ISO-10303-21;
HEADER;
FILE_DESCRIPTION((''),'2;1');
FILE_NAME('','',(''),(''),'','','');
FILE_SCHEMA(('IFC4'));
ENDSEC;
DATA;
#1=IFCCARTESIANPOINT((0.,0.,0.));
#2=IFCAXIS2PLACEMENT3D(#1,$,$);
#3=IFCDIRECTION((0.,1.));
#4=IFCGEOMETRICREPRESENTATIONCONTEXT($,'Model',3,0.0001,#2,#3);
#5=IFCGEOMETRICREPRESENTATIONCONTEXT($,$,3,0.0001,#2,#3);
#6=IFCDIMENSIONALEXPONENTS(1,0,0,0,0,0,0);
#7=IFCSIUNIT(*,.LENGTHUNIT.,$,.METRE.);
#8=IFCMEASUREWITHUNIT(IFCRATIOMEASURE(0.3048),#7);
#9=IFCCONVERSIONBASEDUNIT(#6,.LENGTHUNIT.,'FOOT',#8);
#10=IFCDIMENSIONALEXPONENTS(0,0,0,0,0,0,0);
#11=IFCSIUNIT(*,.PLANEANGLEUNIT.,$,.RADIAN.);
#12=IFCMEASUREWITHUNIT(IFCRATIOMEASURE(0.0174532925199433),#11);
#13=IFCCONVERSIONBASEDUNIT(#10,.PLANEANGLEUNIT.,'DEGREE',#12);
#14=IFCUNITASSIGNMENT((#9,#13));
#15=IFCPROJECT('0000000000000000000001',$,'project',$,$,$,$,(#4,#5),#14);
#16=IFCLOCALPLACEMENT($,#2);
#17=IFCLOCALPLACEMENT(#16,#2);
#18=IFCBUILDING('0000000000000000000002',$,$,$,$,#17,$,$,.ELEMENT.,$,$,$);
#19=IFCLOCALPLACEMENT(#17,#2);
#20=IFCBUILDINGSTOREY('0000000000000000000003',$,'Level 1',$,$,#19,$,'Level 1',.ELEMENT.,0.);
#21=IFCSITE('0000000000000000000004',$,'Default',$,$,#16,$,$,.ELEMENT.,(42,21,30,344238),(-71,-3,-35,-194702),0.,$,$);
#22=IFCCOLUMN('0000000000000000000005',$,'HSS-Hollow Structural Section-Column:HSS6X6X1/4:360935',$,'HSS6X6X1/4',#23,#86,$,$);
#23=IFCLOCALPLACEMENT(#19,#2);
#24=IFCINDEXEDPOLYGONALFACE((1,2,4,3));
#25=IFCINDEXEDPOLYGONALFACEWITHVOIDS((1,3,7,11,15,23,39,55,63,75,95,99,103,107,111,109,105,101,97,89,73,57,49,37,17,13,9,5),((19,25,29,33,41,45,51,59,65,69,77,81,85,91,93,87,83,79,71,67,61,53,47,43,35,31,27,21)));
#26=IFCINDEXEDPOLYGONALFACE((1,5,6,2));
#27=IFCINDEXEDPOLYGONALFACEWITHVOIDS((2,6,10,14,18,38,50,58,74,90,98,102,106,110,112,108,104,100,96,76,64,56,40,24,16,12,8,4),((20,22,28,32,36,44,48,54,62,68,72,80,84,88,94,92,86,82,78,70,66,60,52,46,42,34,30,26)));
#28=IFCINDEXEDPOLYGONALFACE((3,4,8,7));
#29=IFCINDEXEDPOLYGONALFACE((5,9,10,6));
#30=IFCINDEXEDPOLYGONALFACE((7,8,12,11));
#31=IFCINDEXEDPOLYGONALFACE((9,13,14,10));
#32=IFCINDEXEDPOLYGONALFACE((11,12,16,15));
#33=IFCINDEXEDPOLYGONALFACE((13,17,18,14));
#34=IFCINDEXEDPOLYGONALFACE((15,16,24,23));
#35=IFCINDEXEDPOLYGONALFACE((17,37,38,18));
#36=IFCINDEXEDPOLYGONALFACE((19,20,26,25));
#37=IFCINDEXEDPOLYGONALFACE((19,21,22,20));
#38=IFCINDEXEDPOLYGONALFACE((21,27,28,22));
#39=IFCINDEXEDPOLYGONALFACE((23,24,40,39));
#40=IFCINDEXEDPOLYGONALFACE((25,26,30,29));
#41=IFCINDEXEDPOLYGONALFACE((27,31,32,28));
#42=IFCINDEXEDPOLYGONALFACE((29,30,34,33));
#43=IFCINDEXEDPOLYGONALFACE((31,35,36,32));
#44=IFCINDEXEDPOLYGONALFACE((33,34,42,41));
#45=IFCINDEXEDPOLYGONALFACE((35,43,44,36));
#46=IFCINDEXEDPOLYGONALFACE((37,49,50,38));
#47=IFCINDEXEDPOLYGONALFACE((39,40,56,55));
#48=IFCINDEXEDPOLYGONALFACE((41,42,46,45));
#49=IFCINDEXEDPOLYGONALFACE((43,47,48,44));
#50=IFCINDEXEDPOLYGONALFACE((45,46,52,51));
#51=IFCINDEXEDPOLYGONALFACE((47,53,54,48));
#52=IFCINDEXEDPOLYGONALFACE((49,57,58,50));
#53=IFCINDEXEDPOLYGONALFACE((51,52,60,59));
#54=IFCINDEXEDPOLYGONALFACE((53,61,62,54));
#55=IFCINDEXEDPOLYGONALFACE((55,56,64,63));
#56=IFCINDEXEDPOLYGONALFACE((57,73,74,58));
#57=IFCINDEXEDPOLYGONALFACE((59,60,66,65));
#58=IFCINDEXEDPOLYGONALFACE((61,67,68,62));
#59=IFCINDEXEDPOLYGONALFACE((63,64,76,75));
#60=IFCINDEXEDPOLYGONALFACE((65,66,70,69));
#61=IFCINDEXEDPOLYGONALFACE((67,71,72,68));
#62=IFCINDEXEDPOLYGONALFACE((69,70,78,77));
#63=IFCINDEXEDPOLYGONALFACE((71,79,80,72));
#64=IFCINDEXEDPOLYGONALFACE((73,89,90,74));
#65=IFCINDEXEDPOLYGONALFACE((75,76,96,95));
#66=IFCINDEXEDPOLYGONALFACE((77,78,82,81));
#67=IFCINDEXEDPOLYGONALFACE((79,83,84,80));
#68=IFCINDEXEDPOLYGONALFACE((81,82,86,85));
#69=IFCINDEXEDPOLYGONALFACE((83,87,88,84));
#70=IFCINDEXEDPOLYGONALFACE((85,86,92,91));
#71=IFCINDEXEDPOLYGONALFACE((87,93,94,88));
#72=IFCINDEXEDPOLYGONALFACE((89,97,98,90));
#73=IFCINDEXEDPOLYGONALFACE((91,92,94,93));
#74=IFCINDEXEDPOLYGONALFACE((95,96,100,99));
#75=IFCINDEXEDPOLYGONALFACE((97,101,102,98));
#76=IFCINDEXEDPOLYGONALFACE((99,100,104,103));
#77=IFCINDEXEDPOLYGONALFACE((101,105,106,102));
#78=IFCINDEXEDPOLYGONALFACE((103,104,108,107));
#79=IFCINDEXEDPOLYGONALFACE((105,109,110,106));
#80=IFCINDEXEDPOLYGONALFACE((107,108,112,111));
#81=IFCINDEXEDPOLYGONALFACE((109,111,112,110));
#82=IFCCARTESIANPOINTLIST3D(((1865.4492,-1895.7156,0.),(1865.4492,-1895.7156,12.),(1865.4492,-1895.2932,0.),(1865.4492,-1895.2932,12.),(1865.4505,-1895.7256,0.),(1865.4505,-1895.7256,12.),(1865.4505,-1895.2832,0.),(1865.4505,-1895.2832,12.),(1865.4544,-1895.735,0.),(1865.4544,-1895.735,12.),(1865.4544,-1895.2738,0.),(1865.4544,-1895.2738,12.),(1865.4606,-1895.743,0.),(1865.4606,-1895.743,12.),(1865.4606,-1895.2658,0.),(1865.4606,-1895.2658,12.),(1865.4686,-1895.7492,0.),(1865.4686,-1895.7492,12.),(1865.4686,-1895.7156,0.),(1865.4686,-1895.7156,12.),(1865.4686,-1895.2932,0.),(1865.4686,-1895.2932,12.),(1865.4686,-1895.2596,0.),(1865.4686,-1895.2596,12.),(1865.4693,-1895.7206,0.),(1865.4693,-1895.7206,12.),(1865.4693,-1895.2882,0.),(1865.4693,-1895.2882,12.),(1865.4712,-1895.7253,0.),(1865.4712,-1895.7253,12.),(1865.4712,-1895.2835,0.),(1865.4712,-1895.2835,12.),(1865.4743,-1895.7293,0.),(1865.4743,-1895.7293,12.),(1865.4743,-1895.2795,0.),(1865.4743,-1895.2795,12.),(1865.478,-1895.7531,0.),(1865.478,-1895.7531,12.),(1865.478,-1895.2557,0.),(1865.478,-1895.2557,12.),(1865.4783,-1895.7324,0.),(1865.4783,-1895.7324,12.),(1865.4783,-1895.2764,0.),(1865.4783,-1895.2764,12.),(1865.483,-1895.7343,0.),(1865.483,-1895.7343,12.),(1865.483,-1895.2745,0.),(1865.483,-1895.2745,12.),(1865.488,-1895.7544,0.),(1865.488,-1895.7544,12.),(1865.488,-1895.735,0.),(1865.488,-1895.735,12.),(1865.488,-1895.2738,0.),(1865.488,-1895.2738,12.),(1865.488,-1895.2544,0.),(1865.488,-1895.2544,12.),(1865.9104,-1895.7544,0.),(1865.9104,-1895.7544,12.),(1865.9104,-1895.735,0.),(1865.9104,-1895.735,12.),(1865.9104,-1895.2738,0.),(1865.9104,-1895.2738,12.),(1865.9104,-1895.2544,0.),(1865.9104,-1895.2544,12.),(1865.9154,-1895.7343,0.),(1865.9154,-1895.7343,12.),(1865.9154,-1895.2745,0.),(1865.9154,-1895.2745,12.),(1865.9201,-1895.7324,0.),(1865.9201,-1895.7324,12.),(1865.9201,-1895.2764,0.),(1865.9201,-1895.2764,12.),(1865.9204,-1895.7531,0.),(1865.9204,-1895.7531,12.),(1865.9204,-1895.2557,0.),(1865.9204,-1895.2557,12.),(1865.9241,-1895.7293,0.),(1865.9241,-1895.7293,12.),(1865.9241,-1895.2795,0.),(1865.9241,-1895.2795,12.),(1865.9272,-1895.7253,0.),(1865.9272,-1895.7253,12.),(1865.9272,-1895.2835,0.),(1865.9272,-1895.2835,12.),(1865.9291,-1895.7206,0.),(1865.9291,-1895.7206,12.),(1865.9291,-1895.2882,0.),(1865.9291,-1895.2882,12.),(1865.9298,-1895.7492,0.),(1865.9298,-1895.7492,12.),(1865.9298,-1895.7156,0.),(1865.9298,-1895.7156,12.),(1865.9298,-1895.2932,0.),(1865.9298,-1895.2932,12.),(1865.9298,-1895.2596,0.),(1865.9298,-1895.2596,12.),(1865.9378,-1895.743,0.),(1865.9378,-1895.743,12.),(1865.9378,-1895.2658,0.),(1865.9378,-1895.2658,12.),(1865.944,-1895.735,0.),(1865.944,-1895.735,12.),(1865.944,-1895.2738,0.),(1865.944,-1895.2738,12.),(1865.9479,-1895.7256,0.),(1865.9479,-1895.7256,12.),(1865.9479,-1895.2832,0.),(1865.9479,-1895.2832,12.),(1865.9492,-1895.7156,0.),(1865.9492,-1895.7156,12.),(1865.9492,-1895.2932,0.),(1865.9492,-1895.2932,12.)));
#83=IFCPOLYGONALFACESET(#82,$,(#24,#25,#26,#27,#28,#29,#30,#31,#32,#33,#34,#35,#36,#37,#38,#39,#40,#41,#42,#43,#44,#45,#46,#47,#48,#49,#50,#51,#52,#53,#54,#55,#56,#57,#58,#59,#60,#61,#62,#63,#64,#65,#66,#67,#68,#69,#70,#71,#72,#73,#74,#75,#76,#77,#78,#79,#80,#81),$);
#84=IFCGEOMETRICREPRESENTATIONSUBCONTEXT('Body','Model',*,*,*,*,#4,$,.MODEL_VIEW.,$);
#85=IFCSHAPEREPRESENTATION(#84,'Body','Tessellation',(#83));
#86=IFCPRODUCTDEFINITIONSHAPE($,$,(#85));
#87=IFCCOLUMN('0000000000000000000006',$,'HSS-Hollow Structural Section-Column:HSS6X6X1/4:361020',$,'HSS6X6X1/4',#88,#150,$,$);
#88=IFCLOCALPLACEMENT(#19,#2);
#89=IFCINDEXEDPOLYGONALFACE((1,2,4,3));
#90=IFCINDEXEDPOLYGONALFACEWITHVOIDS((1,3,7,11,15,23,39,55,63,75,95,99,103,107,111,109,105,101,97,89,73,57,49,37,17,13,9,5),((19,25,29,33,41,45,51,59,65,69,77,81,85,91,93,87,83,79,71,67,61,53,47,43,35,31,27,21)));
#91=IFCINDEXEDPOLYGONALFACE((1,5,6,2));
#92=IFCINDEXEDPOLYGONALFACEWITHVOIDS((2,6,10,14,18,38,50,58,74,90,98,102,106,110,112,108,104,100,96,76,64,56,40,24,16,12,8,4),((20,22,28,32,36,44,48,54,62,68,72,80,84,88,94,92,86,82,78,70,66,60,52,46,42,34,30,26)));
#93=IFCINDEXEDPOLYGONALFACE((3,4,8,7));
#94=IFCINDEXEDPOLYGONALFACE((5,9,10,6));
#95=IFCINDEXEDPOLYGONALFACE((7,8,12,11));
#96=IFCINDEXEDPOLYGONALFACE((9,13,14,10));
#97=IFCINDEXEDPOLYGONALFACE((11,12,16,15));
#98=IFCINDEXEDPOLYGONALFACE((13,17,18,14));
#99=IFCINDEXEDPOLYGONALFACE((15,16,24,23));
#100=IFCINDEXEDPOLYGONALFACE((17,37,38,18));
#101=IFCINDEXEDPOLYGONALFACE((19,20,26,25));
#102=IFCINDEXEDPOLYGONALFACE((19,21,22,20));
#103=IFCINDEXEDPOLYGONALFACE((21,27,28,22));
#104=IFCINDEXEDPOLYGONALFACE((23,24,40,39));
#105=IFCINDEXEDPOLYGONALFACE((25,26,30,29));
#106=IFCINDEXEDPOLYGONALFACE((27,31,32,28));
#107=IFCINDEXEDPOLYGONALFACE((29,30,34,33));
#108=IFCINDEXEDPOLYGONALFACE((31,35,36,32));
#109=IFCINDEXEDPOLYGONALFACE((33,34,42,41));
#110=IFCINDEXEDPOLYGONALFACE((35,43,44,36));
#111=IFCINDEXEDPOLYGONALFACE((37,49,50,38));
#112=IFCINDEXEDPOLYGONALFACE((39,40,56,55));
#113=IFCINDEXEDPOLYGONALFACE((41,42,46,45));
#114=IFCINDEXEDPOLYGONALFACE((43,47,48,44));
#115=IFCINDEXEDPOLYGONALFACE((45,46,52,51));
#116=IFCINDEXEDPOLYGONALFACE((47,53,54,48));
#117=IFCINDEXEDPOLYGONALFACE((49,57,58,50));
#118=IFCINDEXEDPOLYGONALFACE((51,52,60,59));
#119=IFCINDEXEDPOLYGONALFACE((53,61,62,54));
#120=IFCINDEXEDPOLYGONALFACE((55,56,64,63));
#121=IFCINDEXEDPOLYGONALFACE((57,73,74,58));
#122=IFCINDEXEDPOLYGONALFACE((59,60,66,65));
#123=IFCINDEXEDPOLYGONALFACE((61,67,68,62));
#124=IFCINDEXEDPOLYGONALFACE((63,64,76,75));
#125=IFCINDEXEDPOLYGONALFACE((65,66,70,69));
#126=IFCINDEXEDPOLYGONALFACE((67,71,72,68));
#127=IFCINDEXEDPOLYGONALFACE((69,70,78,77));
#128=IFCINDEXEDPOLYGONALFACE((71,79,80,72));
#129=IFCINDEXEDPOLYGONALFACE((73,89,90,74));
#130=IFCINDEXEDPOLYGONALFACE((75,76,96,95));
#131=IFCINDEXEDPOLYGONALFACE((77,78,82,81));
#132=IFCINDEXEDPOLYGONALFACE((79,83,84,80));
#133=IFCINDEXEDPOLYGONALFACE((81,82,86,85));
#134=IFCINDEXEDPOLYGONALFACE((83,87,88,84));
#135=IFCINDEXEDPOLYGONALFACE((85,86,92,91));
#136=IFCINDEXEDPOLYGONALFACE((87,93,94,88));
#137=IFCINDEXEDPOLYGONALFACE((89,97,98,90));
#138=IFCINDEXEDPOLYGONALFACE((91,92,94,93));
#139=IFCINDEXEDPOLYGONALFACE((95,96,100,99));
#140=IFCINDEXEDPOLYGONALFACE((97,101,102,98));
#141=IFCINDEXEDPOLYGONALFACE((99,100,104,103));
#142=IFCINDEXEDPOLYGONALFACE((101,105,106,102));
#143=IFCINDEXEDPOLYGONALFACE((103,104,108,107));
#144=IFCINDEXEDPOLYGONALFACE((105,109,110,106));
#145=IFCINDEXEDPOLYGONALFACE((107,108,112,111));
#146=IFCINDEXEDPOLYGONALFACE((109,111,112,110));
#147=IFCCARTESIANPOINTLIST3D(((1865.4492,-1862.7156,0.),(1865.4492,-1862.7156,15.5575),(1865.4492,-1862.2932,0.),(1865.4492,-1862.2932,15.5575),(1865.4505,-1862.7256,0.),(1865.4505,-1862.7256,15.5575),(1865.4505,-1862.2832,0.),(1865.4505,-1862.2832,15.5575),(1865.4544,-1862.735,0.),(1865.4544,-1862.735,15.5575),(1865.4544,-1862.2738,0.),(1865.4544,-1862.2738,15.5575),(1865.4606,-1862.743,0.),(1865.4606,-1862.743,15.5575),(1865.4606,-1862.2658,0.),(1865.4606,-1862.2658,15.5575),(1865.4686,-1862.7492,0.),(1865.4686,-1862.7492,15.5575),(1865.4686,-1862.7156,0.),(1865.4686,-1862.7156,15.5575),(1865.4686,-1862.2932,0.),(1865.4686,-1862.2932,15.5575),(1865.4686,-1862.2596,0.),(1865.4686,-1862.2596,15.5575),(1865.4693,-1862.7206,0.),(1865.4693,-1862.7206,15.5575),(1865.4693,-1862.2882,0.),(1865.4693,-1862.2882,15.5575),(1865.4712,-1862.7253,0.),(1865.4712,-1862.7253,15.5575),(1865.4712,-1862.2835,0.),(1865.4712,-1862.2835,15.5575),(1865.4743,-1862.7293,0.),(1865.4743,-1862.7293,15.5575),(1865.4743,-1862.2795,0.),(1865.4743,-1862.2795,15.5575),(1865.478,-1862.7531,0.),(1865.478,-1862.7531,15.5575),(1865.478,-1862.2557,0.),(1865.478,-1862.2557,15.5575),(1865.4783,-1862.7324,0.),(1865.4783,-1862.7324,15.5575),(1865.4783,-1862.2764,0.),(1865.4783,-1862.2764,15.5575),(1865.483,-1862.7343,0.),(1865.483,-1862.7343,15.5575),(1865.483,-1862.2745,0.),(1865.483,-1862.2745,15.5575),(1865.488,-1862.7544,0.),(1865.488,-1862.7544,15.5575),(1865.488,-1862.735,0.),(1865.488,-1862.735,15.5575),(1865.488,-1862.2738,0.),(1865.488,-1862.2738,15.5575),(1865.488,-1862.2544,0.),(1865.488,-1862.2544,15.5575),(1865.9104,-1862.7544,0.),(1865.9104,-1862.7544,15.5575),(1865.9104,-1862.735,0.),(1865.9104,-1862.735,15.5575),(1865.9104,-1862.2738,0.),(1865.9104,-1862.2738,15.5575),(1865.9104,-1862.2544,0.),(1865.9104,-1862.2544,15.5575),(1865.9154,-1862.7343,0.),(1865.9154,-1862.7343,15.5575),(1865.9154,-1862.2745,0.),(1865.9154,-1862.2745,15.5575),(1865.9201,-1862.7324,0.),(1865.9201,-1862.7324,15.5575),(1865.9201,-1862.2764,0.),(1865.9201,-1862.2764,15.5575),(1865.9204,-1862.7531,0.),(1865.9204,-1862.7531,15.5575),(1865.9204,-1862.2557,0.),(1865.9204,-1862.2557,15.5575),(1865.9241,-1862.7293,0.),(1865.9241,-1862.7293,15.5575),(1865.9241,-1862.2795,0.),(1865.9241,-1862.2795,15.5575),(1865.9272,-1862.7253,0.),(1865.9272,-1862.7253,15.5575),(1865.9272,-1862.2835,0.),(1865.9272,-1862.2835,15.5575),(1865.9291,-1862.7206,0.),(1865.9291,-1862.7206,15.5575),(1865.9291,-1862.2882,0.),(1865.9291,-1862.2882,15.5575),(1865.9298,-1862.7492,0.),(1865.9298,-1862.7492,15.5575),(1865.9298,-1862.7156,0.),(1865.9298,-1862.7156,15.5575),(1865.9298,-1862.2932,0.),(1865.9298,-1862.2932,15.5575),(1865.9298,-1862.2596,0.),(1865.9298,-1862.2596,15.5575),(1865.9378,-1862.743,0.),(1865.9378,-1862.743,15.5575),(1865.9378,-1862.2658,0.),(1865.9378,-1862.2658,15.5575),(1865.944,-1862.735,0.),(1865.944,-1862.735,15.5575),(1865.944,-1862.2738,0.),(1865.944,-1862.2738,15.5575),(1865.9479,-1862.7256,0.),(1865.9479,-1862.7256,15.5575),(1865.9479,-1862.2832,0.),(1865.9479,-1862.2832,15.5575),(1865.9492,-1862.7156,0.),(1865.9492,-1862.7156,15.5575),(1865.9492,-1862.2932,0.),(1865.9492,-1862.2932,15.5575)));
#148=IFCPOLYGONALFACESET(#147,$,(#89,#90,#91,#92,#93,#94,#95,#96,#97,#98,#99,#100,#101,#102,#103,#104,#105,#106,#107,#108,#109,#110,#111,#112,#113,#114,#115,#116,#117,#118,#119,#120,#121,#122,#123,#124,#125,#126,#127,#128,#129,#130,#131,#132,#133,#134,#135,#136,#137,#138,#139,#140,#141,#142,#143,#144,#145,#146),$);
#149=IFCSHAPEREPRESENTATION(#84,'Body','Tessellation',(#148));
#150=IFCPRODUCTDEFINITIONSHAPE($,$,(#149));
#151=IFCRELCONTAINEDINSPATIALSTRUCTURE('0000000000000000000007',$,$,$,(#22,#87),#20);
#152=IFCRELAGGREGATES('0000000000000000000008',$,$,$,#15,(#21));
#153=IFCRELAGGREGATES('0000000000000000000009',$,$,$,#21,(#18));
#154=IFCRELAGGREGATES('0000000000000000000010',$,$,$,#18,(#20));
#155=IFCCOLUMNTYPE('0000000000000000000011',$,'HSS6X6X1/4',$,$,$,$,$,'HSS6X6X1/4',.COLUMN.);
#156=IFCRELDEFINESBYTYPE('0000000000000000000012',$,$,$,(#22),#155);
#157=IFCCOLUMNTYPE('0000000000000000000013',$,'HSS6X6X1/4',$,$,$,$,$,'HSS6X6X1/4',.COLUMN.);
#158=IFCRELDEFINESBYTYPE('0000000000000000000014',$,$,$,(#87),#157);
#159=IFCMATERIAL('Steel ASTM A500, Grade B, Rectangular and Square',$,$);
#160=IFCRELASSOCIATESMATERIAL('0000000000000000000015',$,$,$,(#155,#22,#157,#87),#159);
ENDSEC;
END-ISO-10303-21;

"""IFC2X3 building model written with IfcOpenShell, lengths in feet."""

from ifc_helpers import new_model, entity, si_unit, converted_unit, direction, frame, frame_2d, origin, place, context, subcontext, project, spatial, polyline, circle_curve, parameter, trimmed, segment, composite_curve, outline, extrude, source, transform, mapped, material, type_object, type_shapes, element, save


model = new_model("IFC2X3")

# Units and contexts
model_context = context("Model", 3, precision=0.0001, world=origin(), true_north=direction((0.0, 1.0)))
context_of_model = context(None, 3, precision=0.0001, world=origin(), true_north=direction((0.0, 1.0)))
body_context = subcontext(model_context, "Body", "Model", "MODEL_VIEW")
ifc_project = project(units=[converted_unit("LENGTHUNIT", "FOOT", entity("IfcRatioMeasure", 0.3048), si_unit("LENGTHUNIT", "METRE"), dimensions=[1, 0, 0, 0, 0, 0, 0]), converted_unit("PLANEANGLEUNIT", "DEGREE", entity("IfcRatioMeasure", 0.0174532925199433), si_unit("PLANEANGLEUNIT", "RADIAN"), dimensions=[0, 0, 0, 0, 0, 0, 0])], contexts=[model_context, context_of_model])

# Site, building, storey
site_placement = place(None, origin())
site = spatial("IfcSite", under=ifc_project, at=site_placement, Name="Default", CompositionType="ELEMENT", RefLatitude=(42, 21, 30, 344238), RefLongitude=(-71, -3, -35, -194702), RefElevation=0.0)
building_placement = place(site_placement, origin())
building = spatial("IfcBuilding", under=site, at=building_placement, CompositionType="ELEMENT")
storey_placement = place(building_placement, origin())
storey = spatial("IfcBuildingStorey", under=building, at=storey_placement, Name="Level 1", LongName="Level 1", CompositionType="ELEMENT", Elevation=0.0)

# Columns
ifc_material_1 = material(Name="Steel ASTM A500, Grade B, Rectangular and Square")
column_type_1 = type_object("IfcColumnType", Name="HSS6X6X1/4", ElementType="HSS6X6X1/4", PredefinedType="COLUMN", material=ifc_material_1)
shared_shape_1 = source(origin(), body_context, "Body", "SweptSolid", [
    extrude(outline(composite_curve([segment(polyline([(-0.2112, -0.25), (0.2112, -0.25)]), True, "CONTINUOUS"), segment(trimmed(circle_curve(frame_2d((0.2112, -0.2112), x_axis=(-1.0, 0.0)), 0.0388), [parameter(90.0)], [parameter(180.0)], True, "PARAMETER"), True, "CONTINUOUS"), segment(polyline([(0.25, -0.2112), (0.25, 0.2112)]), True, "CONTINUOUS"), segment(trimmed(circle_curve(frame_2d((0.2112, 0.2112), x_axis=(-1.0, 0.0)), 0.0388), [parameter(180.0)], [parameter(270.0)], True, "PARAMETER"), True, "CONTINUOUS"), segment(polyline([(0.2112, 0.25), (-0.2112, 0.25)]), True, "CONTINUOUS"), segment(trimmed(circle_curve(frame_2d((-0.2112, 0.2112), x_axis=(-1.0, 0.0)), 0.0388), [parameter(270.0)], [parameter(360.0)], True, "PARAMETER"), True, "CONTINUOUS"), segment(polyline([(-0.25, 0.2112), (-0.25, -0.2112)]), True, "CONTINUOUS"), segment(trimmed(circle_curve(frame_2d((-0.2112, -0.2112), x_axis=(-1.0, 0.0)), 0.0388), [parameter(360.0)], [parameter(90.0)], True, "PARAMETER"), True, "CONTINUOUS")], self_intersect=False), holes=[composite_curve([segment(trimmed(circle_curve(frame_2d((-0.2112, -0.2112), x_axis=(-1.0, 0.0)), 0.0194), [parameter(0.0)], [parameter(90.0)], True, "PARAMETER"), False, "CONTINUOUS"), segment(polyline([(-0.2306, -0.2112), (-0.2306, 0.2112)]), True, "CONTINUOUS"), segment(trimmed(circle_curve(frame_2d((-0.2112, 0.2112), x_axis=(-1.0, 0.0)), 0.0194), [parameter(270.0)], [parameter(360.0)], True, "PARAMETER"), False, "CONTINUOUS"), segment(polyline([(-0.2112, 0.2306), (0.2112, 0.2306)]), True, "CONTINUOUS"), segment(trimmed(circle_curve(frame_2d((0.2112, 0.2112), x_axis=(-1.0, 0.0)), 0.0194), [parameter(180.0)], [parameter(270.0)], True, "PARAMETER"), False, "CONTINUOUS"), segment(polyline([(0.2306, 0.2112), (0.2306, -0.2112)]), True, "CONTINUOUS"), segment(trimmed(circle_curve(frame_2d((0.2112, -0.2112), x_axis=(-1.0, 0.0)), 0.0194), [parameter(90.0)], [parameter(180.0)], True, "PARAMETER"), False, "CONTINUOUS"), segment(polyline([(0.2112, -0.2306), (-0.2112, -0.2306)]), True, "CONTINUOUS")], self_intersect=False)]), frame((0.0, 0.0, 0.0), z_axis=(0.0, 0.0, 1.0), x_axis=(-1.0, 0.0, 0.0)), (0.0, 0.0, 1.0), 12.0),
])
type_shapes(column_type_1, [shared_shape_1])
column_1_placement = place(storey_placement, frame((1865.6992, -1895.5044, 0.0), z_axis=(0.0, 0.0, 1.0), x_axis=(-1.0, 0.0, 0.0)))
element("IfcColumn", 1, at=column_1_placement, inside=storey, type_object=column_type_1, material=ifc_material_1, Name="HSS-Hollow Structural Section-Column:HSS6X6X1/4:360935", ObjectType="HSS6X6X1/4", context=body_context, shape_type="MappedRepresentation", body=[
    mapped(shared_shape_1, transform((0.0, 0.0, 0.0), scale=1.0)),
])
column_type_2 = type_object("IfcColumnType", Name="HSS6X6X1/4", ElementType="HSS6X6X1/4", PredefinedType="COLUMN", material=ifc_material_1)
shared_shape_2 = source(origin(), body_context, "Body", "SweptSolid", [
    extrude(outline(composite_curve([segment(polyline([(-0.2112, -0.25), (0.2112, -0.25)]), True, "CONTINUOUS"), segment(trimmed(circle_curve(frame_2d((0.2112, -0.2112), x_axis=(-1.0, 0.0)), 0.0388), [parameter(90.0)], [parameter(180.0)], True, "PARAMETER"), True, "CONTINUOUS"), segment(polyline([(0.25, -0.2112), (0.25, 0.2112)]), True, "CONTINUOUS"), segment(trimmed(circle_curve(frame_2d((0.2112, 0.2112), x_axis=(-1.0, 0.0)), 0.0388), [parameter(180.0)], [parameter(270.0)], True, "PARAMETER"), True, "CONTINUOUS"), segment(polyline([(0.2112, 0.25), (-0.2112, 0.25)]), True, "CONTINUOUS"), segment(trimmed(circle_curve(frame_2d((-0.2112, 0.2112), x_axis=(-1.0, 0.0)), 0.0388), [parameter(270.0)], [parameter(360.0)], True, "PARAMETER"), True, "CONTINUOUS"), segment(polyline([(-0.25, 0.2112), (-0.25, -0.2112)]), True, "CONTINUOUS"), segment(trimmed(circle_curve(frame_2d((-0.2112, -0.2112), x_axis=(-1.0, 0.0)), 0.0388), [parameter(360.0)], [parameter(90.0)], True, "PARAMETER"), True, "CONTINUOUS")], self_intersect=False), holes=[composite_curve([segment(trimmed(circle_curve(frame_2d((-0.2112, -0.2112), x_axis=(-1.0, 0.0)), 0.0194), [parameter(0.0)], [parameter(90.0)], True, "PARAMETER"), False, "CONTINUOUS"), segment(polyline([(-0.2306, -0.2112), (-0.2306, 0.2112)]), True, "CONTINUOUS"), segment(trimmed(circle_curve(frame_2d((-0.2112, 0.2112), x_axis=(-1.0, 0.0)), 0.0194), [parameter(270.0)], [parameter(360.0)], True, "PARAMETER"), False, "CONTINUOUS"), segment(polyline([(-0.2112, 0.2306), (0.2112, 0.2306)]), True, "CONTINUOUS"), segment(trimmed(circle_curve(frame_2d((0.2112, 0.2112), x_axis=(-1.0, 0.0)), 0.0194), [parameter(180.0)], [parameter(270.0)], True, "PARAMETER"), False, "CONTINUOUS"), segment(polyline([(0.2306, 0.2112), (0.2306, -0.2112)]), True, "CONTINUOUS"), segment(trimmed(circle_curve(frame_2d((0.2112, -0.2112), x_axis=(-1.0, 0.0)), 0.0194), [parameter(90.0)], [parameter(180.0)], True, "PARAMETER"), False, "CONTINUOUS"), segment(polyline([(0.2112, -0.2306), (-0.2112, -0.2306)]), True, "CONTINUOUS")], self_intersect=False)]), frame((1865.6992, -1862.5044, 0.0), z_axis=(0.0, 0.0, 1.0), x_axis=(0.0, 1.0, 0.0)), (0.0, 0.0, 1.0), 15.5575),
])
type_shapes(column_type_2, [shared_shape_2])
column_2_placement = place(storey_placement, origin())
element("IfcColumn", 2, at=column_2_placement, inside=storey, type_object=column_type_2, material=ifc_material_1, Name="HSS-Hollow Structural Section-Column:HSS6X6X1/4:361020", ObjectType="HSS6X6X1/4", context=body_context, shape_type="MappedRepresentation", body=[
    mapped(shared_shape_2, transform((0.0, 0.0, 0.0), scale=1.0)),
])

save(model, "model.ifc")
